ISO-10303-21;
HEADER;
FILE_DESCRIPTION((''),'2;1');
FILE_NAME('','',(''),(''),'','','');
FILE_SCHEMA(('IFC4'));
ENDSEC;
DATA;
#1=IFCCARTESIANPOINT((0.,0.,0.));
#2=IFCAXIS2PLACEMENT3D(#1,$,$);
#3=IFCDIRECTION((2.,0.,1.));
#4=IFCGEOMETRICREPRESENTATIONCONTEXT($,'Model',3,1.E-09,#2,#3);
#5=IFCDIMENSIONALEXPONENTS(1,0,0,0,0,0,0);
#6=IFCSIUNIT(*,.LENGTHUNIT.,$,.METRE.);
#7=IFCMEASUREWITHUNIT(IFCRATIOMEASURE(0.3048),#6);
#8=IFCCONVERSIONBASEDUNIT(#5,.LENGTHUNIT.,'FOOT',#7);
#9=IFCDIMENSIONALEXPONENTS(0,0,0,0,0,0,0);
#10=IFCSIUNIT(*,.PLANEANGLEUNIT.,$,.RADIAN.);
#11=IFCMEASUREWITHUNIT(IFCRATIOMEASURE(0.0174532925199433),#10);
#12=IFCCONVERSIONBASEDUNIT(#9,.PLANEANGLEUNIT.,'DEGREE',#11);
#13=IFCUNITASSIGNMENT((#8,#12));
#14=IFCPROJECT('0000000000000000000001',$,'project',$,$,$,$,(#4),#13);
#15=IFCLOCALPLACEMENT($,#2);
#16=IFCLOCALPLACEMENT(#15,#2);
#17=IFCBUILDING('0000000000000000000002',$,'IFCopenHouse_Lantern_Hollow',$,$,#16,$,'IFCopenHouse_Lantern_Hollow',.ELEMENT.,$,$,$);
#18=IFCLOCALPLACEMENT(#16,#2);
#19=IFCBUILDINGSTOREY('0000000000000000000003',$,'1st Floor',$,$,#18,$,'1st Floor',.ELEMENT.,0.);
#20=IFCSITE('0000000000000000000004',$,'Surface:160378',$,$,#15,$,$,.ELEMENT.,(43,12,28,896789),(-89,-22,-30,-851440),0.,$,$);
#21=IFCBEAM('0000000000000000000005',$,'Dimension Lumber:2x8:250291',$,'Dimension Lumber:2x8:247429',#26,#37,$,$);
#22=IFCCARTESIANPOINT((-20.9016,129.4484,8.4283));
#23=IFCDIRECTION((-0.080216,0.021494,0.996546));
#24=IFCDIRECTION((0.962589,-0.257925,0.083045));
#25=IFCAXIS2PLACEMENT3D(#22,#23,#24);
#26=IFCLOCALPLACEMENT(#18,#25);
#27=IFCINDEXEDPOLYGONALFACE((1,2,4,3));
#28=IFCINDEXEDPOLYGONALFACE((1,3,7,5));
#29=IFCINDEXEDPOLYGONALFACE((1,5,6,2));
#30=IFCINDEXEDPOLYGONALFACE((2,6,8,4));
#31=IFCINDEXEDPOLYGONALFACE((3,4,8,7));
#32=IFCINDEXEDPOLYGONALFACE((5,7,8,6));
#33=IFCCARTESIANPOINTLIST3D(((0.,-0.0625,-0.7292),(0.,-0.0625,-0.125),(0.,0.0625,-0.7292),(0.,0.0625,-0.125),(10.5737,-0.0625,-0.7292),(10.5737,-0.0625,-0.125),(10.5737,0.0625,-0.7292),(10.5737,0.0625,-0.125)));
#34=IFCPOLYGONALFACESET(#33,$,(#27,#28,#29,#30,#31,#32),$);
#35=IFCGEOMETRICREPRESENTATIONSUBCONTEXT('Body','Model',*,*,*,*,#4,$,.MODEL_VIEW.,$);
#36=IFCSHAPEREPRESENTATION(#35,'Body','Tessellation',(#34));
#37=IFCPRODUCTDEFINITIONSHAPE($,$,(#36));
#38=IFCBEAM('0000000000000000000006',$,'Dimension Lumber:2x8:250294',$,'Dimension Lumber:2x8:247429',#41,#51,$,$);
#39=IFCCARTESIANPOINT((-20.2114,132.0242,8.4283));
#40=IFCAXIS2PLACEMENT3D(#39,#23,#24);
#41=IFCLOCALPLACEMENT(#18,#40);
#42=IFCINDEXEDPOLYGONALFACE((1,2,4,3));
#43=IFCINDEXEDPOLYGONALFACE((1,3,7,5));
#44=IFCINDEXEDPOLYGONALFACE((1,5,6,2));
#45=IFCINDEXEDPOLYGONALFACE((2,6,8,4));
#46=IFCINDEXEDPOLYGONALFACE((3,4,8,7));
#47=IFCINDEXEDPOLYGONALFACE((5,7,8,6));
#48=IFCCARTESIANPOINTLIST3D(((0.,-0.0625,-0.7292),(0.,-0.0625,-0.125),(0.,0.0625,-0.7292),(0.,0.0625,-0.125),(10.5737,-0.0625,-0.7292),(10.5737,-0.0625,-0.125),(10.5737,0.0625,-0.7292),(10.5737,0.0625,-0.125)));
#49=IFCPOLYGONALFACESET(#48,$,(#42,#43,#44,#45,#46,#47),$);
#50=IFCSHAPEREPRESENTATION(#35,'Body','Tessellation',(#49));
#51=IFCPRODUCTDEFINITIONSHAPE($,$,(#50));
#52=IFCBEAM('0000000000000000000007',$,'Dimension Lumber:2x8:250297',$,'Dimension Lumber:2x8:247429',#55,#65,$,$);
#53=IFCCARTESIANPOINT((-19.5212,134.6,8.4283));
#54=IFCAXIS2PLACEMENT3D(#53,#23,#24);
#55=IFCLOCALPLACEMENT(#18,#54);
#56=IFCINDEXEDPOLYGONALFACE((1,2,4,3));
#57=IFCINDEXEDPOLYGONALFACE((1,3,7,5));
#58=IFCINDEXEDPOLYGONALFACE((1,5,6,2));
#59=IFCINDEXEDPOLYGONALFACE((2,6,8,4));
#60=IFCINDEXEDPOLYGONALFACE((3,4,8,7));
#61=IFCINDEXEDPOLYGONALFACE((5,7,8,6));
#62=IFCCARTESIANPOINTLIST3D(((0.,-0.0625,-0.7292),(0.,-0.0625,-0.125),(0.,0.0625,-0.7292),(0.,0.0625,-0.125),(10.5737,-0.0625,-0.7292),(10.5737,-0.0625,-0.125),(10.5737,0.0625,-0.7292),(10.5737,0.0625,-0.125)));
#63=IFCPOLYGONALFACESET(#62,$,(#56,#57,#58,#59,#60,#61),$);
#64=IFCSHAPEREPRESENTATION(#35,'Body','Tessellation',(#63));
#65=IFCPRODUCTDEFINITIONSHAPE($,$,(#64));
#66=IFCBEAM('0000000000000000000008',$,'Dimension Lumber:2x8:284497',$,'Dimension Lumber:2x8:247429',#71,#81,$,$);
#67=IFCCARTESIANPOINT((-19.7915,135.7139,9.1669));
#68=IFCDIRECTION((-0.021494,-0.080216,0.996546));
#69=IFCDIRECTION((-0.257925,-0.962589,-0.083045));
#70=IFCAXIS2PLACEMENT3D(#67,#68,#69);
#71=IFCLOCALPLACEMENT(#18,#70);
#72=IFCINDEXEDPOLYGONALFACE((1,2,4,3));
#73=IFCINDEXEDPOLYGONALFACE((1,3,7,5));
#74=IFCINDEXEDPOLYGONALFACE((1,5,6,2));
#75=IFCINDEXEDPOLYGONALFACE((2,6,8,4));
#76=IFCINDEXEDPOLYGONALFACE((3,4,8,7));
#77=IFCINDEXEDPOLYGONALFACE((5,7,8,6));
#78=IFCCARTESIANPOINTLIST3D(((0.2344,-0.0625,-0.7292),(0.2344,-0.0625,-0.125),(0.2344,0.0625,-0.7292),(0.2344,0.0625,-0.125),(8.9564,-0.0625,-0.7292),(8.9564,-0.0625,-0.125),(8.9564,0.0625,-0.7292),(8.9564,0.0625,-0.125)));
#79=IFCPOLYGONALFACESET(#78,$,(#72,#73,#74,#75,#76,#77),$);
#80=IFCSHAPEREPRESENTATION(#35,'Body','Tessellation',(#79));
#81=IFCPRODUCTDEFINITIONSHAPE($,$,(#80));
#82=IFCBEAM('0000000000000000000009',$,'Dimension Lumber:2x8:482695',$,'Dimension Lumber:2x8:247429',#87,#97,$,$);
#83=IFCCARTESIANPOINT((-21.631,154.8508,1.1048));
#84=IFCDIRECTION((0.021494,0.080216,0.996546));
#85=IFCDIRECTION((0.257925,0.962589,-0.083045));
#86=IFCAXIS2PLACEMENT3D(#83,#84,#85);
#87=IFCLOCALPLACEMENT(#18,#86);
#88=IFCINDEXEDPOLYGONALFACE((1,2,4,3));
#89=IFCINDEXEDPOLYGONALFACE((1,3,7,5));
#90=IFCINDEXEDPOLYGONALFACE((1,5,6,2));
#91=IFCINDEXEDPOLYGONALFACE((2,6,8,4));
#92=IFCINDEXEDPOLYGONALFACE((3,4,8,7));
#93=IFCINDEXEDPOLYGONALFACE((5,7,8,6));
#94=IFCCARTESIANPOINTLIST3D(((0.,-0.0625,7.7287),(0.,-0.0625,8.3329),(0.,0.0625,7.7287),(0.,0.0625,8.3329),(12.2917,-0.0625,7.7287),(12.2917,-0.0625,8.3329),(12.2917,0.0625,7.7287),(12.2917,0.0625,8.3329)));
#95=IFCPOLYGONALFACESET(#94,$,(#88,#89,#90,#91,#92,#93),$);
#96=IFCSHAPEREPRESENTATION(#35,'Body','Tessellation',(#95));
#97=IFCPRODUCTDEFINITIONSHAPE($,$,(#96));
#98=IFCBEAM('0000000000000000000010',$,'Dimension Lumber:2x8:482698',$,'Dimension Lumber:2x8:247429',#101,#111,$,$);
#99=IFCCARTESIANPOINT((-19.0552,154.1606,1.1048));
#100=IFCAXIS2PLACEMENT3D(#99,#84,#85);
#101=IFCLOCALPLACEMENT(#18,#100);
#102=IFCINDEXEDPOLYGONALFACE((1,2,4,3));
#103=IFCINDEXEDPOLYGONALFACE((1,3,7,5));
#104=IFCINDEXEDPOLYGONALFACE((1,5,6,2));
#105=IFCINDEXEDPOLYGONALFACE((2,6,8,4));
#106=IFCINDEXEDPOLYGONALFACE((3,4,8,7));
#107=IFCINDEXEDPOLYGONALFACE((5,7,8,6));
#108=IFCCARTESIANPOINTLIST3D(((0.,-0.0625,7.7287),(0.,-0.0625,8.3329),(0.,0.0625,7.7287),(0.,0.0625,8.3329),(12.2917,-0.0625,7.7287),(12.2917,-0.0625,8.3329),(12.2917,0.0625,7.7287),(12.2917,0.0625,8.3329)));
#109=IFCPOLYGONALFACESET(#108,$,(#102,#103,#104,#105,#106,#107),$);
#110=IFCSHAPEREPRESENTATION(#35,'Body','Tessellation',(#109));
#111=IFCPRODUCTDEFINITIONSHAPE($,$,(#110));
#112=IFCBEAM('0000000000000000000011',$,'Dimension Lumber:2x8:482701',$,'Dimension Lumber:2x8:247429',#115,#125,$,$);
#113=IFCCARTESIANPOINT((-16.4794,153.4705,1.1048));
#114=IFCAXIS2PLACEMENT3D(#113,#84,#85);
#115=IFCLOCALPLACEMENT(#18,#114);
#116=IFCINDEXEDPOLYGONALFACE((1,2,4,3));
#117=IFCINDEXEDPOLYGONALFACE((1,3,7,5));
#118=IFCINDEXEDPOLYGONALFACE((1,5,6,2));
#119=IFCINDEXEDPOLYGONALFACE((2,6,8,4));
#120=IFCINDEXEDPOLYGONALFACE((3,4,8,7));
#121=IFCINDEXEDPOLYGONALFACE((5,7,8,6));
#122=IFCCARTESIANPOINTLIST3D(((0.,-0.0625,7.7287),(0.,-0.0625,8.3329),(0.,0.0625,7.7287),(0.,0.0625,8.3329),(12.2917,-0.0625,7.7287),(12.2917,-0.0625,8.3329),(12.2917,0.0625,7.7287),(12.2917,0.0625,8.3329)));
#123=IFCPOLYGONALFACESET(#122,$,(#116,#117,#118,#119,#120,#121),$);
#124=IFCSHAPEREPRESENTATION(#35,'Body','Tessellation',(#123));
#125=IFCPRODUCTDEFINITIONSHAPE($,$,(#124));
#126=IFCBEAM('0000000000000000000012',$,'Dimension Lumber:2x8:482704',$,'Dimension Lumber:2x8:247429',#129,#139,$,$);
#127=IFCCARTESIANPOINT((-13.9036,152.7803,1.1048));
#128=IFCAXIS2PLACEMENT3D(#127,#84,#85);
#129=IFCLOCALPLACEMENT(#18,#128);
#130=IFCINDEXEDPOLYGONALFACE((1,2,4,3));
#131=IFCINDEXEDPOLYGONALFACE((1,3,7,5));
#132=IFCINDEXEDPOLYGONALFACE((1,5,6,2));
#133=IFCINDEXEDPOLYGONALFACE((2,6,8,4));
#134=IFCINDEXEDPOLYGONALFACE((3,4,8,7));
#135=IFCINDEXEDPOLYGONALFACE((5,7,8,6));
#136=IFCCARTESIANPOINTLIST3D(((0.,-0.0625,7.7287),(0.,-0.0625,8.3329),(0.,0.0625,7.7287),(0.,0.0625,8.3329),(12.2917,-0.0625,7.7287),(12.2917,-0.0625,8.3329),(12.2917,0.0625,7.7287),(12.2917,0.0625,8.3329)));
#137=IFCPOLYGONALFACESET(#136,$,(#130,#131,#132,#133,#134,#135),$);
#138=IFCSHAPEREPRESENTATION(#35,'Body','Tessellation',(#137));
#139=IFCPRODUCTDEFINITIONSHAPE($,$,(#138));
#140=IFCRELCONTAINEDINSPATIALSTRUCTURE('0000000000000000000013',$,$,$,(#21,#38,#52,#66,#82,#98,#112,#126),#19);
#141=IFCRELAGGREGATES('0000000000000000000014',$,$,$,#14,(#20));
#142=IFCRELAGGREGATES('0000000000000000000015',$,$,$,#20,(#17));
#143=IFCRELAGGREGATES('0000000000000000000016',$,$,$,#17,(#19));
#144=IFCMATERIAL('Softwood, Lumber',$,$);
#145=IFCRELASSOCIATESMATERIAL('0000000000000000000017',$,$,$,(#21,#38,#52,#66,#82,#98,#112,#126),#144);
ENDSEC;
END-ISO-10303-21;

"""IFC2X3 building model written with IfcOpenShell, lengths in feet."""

from ifc_helpers import new_model, entity, si_unit, converted_unit, direction, frame, frame_2d, origin, place, context, subcontext, project, spatial, rectangle, extrude, material, element, save


model = new_model("IFC2X3")

# Units and contexts
model_context = context("Model", 3, precision=1e-09, world=origin(), true_north=direction((2.0, 0.0, 1.0)))
body_context = subcontext(model_context, "Body", "Model", "MODEL_VIEW")
ifc_project = project(units=[converted_unit("LENGTHUNIT", "FOOT", entity("IfcRatioMeasure", 0.3048), si_unit("LENGTHUNIT", "METRE"), dimensions=[1, 0, 0, 0, 0, 0, 0]), converted_unit("PLANEANGLEUNIT", "DEGREE", entity("IfcRatioMeasure", 0.0174532925199433), si_unit("PLANEANGLEUNIT", "RADIAN"), dimensions=[0, 0, 0, 0, 0, 0, 0])], contexts=[model_context])

# Site, building, storey
site_placement = place(None, origin())
site = spatial("IfcSite", under=ifc_project, at=site_placement, Name="Surface:160378", CompositionType="ELEMENT", RefLatitude=(43, 12, 28, 896789), RefLongitude=(-89, -22, -30, -851440), RefElevation=0.0)
building_placement = place(site_placement, origin())
building = spatial("IfcBuilding", under=site, at=building_placement, Name="IFCopenHouse_Lantern_Hollow", LongName="IFCopenHouse_Lantern_Hollow", CompositionType="ELEMENT")
storey_placement = place(building_placement, origin())
storey = spatial("IfcBuildingStorey", under=building, at=storey_placement, Name="1st Floor", LongName="1st Floor", CompositionType="ELEMENT", Elevation=0.0)

# Beams
ifc_material_1 = material(Name="Softwood, Lumber")
beam_1_placement = place(storey_placement, frame((-20.9016, 129.4484, 8.4283), z_axis=(-0.080216, 0.021494, 0.996546), x_axis=(0.962589, -0.257925, 0.083045)))
element("IfcBeam", 1, at=beam_1_placement, inside=storey, material=ifc_material_1, Name="Dimension Lumber:2x8:250291", ObjectType="Dimension Lumber:2x8:247429", context=body_context, shape_type="SweptSolid", body=[
    extrude(rectangle(XDim=0.6042, YDim=0.125, at=frame_2d((0.0, 0.0), x_axis=(1.0, 0.0))), frame((0.0, 0.0, -0.4271), z_axis=(1.0, 0.0, 0.0), x_axis=(0.0, 0.0, -1.0)), (0.0, 0.0, 1.0), 10.5737),
])
for number, where, z_axis, x_axis, name in (
    (2, (-20.2114, 132.0242, 8.4283), (-0.080216, 0.021494, 0.996546), (0.962589, -0.257925, 0.083045), "Dimension Lumber:2x8:250294"),
    (3, (-19.5212, 134.6, 8.4283), (-0.080216, 0.021494, 0.996546), (0.962589, -0.257925, 0.083045), "Dimension Lumber:2x8:250297"),
):
    element("IfcBeam", number, at=place(storey_placement, frame(where, z_axis=z_axis, x_axis=x_axis)), inside=storey, material=ifc_material_1, Name=name, ObjectType="Dimension Lumber:2x8:247429", context=body_context, shape_type="SweptSolid", body=[
        extrude(rectangle(XDim=0.6042, YDim=0.125, at=frame_2d((0.0, 0.0), x_axis=(1.0, 0.0))), frame((0.0, 0.0, -0.4271), z_axis=(1.0, 0.0, 0.0), x_axis=(0.0, 0.0, -1.0)), (0.0, 0.0, 1.0), 10.5737),
    ])
beam_2_placement = place(storey_placement, frame((-19.7915, 135.7139, 9.1669), z_axis=(-0.021494, -0.080216, 0.996546), x_axis=(-0.257925, -0.962589, -0.083045)))
element("IfcBeam", 4, at=beam_2_placement, inside=storey, material=ifc_material_1, Name="Dimension Lumber:2x8:284497", ObjectType="Dimension Lumber:2x8:247429", context=body_context, shape_type="SweptSolid", body=[
    extrude(rectangle(XDim=0.6042, YDim=0.125, at=frame_2d((0.0, 0.0), x_axis=(1.0, 0.0))), frame((0.2344, 0.0, -0.4271), z_axis=(1.0, 0.0, 0.0), x_axis=(0.0, 0.0, -1.0)), (0.0, 0.0, 1.0), 8.722),
])
beam_3_placement = place(storey_placement, frame((-21.631, 154.8508, 1.1048), z_axis=(0.021494, 0.080216, 0.996546), x_axis=(0.257925, 0.962589, -0.083045)))
element("IfcBeam", 5, at=beam_3_placement, inside=storey, material=ifc_material_1, Name="Dimension Lumber:2x8:482695", ObjectType="Dimension Lumber:2x8:247429", context=body_context, shape_type="SweptSolid", body=[
    extrude(rectangle(XDim=0.6042, YDim=0.125, at=frame_2d((0.0, 0.0), x_axis=(1.0, 0.0))), frame((0.0, 0.0, 8.0308), z_axis=(1.0, 0.0, 0.0), x_axis=(0.0, 0.0, -1.0)), (0.0, 0.0, 1.0), 12.2917),
])
beam_4_placement = place(storey_placement, frame((-19.0552, 154.1606, 1.1048), z_axis=(0.021494, 0.080216, 0.996546), x_axis=(0.257925, 0.962589, -0.083045)))
element("IfcBeam", 6, at=beam_4_placement, inside=storey, material=ifc_material_1, Name="Dimension Lumber:2x8:482698", ObjectType="Dimension Lumber:2x8:247429", context=body_context, shape_type="SweptSolid", body=[
    extrude(rectangle(XDim=0.6042, YDim=0.125, at=frame_2d((0.0, 0.0), x_axis=(1.0, 0.0))), frame((0.0, 0.0, 8.0308), z_axis=(1.0, 0.0, 0.0), x_axis=(0.0, 0.0, -1.0)), (0.0, 0.0, 1.0), 12.2917),
])
beam_5_placement = place(storey_placement, frame((-16.4794, 153.4705, 1.1048), z_axis=(0.021494, 0.080216, 0.996546), x_axis=(0.257925, 0.962589, -0.083045)))
element("IfcBeam", 7, at=beam_5_placement, inside=storey, material=ifc_material_1, Name="Dimension Lumber:2x8:482701", ObjectType="Dimension Lumber:2x8:247429", context=body_context, shape_type="SweptSolid", body=[
    extrude(rectangle(XDim=0.6042, YDim=0.125, at=frame_2d((0.0, 0.0), x_axis=(1.0, 0.0))), frame((0.0, 0.0, 8.0308), z_axis=(1.0, 0.0, 0.0), x_axis=(0.0, 0.0, -1.0)), (0.0, 0.0, 1.0), 12.2917),
])
beam_6_placement = place(storey_placement, frame((-13.9036, 152.7803, 1.1048), z_axis=(0.021494, 0.080216, 0.996546), x_axis=(0.257925, 0.962589, -0.083045)))
element("IfcBeam", 8, at=beam_6_placement, inside=storey, material=ifc_material_1, Name="Dimension Lumber:2x8:482704", ObjectType="Dimension Lumber:2x8:247429", context=body_context, shape_type="SweptSolid", body=[
    extrude(rectangle(XDim=0.6042, YDim=0.125, at=frame_2d((0.0, 0.0), x_axis=(1.0, 0.0))), frame((0.0, 0.0, 8.0308), z_axis=(1.0, 0.0, 0.0), x_axis=(0.0, 0.0, -1.0)), (0.0, 0.0, 1.0), 12.2917),
])

save(model, "model.ifc")
